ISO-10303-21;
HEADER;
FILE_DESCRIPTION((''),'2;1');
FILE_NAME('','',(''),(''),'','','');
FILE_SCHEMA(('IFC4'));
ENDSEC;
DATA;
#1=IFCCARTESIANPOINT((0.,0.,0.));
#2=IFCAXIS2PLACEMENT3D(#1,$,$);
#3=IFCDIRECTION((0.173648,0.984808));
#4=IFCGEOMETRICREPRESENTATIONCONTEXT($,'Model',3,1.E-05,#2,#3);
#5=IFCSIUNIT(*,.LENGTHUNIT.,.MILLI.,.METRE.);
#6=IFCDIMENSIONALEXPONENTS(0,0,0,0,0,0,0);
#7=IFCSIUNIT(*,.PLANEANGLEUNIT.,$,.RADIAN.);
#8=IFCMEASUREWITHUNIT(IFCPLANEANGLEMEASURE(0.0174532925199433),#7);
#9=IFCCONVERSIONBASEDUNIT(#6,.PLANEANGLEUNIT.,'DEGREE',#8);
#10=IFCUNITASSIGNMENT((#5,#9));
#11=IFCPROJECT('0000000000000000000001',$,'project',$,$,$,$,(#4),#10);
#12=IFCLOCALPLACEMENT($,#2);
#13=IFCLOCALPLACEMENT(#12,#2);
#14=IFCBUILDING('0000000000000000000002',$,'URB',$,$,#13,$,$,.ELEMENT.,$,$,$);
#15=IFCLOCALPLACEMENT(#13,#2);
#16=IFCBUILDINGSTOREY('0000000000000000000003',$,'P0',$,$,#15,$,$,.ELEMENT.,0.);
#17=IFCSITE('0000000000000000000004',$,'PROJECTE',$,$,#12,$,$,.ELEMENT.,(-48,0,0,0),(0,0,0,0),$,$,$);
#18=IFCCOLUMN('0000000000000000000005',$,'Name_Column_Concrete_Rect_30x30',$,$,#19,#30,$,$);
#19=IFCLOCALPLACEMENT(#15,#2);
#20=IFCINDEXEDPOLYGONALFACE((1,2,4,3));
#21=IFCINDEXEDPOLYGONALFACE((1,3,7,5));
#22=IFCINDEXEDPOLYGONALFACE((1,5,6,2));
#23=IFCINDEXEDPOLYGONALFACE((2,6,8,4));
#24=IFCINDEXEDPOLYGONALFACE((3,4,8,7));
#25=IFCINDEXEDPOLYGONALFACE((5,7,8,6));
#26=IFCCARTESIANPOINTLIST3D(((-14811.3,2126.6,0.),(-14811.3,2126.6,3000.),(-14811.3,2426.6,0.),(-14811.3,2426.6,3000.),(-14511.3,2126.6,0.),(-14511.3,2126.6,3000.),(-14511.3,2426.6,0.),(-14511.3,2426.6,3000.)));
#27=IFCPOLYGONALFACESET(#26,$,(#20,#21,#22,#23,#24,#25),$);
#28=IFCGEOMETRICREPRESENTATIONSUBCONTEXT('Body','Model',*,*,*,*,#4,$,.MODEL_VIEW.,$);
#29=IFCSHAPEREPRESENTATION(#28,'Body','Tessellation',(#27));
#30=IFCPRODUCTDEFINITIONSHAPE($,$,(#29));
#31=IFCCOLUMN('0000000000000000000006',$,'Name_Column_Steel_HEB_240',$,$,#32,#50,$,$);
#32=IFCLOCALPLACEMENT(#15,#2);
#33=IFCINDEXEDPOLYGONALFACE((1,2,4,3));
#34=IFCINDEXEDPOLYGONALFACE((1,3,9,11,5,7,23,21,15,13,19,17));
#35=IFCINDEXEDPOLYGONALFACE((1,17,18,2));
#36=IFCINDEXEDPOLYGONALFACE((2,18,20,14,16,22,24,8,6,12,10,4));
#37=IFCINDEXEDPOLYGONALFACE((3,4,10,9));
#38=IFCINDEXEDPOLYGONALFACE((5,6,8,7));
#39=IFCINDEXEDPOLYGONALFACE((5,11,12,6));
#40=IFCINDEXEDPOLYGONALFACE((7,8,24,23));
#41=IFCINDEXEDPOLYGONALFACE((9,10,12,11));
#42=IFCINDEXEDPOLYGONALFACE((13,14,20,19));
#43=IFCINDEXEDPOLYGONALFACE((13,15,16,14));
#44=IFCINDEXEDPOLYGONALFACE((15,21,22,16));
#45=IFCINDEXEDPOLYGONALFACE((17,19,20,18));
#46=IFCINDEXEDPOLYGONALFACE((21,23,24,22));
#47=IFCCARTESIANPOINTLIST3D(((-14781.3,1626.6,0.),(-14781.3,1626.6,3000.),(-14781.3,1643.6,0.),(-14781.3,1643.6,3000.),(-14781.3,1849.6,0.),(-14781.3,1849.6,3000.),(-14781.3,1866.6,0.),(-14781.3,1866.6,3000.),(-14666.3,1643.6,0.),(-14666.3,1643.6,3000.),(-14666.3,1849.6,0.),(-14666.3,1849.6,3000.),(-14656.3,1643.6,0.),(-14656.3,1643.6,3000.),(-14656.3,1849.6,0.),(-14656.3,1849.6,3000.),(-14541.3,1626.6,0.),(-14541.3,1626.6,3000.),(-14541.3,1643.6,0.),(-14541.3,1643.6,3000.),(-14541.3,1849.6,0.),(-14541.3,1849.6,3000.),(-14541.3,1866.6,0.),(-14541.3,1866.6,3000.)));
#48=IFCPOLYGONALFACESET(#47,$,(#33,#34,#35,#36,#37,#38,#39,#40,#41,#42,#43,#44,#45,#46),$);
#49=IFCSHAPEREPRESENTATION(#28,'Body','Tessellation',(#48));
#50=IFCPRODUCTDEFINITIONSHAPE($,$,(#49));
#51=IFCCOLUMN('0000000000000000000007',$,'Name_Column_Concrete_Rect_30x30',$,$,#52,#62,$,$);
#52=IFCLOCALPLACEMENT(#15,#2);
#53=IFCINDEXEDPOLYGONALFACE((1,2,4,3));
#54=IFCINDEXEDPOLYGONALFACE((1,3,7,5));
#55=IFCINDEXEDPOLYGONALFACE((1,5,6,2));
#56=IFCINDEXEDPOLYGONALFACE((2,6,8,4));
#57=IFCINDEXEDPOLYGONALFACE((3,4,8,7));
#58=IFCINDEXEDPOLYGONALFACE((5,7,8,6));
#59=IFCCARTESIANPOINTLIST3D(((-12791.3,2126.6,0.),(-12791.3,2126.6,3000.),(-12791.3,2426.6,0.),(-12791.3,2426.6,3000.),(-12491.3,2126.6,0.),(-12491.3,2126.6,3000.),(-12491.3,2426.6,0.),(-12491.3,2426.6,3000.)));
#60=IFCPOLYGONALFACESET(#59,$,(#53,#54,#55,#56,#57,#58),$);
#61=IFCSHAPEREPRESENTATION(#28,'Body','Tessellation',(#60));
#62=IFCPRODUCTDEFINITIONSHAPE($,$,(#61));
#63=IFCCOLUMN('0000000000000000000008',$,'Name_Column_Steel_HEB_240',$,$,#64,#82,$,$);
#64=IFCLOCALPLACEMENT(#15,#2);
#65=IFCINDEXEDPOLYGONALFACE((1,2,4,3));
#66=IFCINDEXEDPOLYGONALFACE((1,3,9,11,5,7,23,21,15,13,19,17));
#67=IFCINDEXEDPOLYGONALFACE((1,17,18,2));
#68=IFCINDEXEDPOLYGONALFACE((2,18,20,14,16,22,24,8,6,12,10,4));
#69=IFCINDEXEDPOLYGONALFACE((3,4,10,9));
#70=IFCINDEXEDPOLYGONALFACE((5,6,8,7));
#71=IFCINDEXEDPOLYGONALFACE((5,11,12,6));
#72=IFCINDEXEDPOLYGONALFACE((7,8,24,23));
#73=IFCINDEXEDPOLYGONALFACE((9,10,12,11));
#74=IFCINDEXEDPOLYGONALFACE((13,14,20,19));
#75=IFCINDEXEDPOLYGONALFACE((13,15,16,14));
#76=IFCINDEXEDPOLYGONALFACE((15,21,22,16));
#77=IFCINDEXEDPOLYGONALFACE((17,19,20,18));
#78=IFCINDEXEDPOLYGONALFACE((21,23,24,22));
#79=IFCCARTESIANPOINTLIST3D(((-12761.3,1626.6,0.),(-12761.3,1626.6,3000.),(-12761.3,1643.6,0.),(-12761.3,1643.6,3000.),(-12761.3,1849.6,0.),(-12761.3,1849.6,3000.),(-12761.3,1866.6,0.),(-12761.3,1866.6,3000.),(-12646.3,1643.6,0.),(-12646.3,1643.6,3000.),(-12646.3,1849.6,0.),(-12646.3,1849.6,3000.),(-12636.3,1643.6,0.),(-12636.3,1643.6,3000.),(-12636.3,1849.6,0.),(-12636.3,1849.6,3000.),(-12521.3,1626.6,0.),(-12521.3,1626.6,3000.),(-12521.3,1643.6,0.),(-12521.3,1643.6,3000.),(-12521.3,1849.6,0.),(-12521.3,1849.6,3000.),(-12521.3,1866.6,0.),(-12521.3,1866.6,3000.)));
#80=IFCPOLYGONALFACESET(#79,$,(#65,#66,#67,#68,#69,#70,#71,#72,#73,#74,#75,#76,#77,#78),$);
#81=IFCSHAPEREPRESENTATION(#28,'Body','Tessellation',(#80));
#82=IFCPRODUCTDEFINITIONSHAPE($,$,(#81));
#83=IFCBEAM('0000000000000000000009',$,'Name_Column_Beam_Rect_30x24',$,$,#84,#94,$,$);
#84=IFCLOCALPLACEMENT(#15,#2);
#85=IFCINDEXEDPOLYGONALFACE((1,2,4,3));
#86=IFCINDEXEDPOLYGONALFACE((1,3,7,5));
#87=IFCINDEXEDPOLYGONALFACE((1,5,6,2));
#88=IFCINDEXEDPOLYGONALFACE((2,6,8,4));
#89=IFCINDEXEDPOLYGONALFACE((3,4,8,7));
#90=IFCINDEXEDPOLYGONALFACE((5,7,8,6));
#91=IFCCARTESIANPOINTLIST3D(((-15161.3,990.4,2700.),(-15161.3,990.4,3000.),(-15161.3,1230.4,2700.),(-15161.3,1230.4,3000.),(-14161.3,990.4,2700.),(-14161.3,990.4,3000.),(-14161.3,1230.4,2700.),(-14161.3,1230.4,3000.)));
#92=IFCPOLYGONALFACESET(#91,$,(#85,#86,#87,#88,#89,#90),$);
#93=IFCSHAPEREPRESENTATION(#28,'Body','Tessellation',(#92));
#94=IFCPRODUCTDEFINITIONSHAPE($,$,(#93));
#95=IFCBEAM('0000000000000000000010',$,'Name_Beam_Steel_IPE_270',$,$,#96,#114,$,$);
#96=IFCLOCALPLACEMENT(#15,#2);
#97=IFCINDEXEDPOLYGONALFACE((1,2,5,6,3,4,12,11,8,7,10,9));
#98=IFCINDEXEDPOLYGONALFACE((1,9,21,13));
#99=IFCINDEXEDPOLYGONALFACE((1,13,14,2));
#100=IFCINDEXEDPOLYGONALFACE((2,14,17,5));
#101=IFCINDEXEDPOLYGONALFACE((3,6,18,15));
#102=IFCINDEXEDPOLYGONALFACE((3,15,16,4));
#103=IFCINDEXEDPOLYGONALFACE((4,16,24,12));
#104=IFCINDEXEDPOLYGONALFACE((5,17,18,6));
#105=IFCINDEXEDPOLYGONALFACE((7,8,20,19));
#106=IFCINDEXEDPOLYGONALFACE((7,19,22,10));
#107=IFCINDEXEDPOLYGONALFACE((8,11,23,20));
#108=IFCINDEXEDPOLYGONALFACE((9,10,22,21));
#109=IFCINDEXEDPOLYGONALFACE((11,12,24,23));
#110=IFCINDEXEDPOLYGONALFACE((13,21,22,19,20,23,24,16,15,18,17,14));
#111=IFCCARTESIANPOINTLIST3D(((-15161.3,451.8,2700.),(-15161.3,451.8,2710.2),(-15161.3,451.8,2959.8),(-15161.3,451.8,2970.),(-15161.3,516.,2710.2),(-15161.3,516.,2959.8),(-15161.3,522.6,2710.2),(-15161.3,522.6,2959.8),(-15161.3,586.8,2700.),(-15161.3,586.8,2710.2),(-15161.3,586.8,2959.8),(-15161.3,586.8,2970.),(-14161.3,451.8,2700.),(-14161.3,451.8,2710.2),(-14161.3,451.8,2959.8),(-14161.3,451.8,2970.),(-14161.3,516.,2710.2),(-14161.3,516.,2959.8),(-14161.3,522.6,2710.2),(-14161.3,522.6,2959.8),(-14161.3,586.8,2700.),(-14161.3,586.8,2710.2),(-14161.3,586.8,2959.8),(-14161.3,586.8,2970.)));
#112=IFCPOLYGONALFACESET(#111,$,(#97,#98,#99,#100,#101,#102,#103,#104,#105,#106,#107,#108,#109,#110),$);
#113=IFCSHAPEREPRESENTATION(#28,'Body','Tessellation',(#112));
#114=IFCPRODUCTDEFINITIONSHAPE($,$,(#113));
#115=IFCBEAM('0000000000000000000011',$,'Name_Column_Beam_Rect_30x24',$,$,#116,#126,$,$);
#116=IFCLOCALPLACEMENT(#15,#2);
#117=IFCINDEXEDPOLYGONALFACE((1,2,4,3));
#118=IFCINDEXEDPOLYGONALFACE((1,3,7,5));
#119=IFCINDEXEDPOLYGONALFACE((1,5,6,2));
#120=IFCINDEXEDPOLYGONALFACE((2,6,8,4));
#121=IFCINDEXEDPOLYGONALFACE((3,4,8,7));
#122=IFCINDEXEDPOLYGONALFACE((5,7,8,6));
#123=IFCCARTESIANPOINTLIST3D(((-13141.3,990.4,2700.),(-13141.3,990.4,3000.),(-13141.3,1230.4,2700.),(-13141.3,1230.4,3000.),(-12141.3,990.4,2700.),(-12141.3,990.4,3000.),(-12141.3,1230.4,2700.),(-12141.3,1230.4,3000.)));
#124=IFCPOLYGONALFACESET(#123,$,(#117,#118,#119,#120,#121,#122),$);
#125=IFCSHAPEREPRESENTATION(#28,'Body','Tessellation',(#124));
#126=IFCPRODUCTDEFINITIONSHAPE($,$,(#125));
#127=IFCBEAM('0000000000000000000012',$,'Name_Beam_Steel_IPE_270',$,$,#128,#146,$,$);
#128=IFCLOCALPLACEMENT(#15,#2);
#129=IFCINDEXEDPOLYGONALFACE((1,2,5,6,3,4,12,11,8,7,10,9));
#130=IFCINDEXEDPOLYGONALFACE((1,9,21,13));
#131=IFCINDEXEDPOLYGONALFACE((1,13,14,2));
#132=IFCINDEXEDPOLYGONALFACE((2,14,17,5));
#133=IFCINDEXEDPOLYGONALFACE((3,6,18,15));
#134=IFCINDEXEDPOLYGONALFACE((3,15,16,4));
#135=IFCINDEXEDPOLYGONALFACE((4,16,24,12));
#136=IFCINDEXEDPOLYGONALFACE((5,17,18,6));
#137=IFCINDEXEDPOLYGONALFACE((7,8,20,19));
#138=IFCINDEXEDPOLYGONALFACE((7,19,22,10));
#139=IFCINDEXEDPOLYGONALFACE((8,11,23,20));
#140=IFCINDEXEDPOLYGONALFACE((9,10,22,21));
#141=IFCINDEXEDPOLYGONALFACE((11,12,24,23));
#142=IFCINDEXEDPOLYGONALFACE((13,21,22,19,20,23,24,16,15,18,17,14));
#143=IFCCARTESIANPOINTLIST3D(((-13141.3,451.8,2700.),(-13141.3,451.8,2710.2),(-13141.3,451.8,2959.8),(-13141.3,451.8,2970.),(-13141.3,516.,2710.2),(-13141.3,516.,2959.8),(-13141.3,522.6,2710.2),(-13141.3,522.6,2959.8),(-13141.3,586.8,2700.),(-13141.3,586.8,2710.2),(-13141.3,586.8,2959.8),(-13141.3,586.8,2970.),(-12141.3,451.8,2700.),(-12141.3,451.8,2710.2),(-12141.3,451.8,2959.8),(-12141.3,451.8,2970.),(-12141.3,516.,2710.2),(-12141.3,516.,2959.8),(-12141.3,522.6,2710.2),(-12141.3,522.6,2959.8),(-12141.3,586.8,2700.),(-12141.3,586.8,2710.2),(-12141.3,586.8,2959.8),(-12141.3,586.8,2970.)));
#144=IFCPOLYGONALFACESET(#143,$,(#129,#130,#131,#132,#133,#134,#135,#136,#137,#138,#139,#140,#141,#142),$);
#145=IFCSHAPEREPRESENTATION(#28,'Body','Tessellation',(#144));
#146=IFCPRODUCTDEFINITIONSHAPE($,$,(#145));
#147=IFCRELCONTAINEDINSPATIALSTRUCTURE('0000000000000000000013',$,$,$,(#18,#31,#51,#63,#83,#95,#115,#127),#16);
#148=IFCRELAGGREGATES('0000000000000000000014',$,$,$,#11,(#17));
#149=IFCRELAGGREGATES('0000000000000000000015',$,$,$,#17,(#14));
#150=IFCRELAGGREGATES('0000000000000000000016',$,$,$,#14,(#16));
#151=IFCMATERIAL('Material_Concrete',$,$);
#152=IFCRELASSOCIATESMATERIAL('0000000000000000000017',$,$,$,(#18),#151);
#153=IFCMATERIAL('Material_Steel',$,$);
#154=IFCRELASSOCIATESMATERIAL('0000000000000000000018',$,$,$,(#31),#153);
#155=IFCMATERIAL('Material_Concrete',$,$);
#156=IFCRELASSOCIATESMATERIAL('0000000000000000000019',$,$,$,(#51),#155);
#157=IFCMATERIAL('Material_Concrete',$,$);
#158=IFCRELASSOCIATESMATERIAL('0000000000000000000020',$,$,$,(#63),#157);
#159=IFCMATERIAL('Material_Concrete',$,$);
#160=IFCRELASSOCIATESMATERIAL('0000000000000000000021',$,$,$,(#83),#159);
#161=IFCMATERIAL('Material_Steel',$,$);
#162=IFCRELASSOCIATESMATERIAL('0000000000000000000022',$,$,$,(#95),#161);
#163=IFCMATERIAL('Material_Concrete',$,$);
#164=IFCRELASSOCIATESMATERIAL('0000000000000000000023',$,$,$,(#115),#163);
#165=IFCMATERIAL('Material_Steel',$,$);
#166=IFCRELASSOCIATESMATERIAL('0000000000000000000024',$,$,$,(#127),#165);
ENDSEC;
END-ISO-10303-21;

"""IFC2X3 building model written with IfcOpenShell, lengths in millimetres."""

from ifc_helpers import new_model, entity, si_unit, converted_unit, direction, frame, frame_2d, origin, origin_with_axes, place, context, subcontext, project, spatial, polyline, rectangle, outline, extrude, material, element, save


model = new_model("IFC2X3")

# Units and contexts
model_context = context("Model", 3, precision=1e-05, world=origin(), true_north=direction((0.173648, 0.984808)))
body_context = subcontext(model_context, "Body", "Model", "MODEL_VIEW")
ifc_project = project(units=[si_unit("LENGTHUNIT", "METRE", prefix="MILLI"), converted_unit("PLANEANGLEUNIT", "DEGREE", entity("IfcPlaneAngleMeasure", 0.0174532925199433), si_unit("PLANEANGLEUNIT", "RADIAN"), dimensions=[0, 0, 0, 0, 0, 0, 0])], contexts=[model_context])

# Site, building, storey
site_placement = place(None, origin())
site = spatial("IfcSite", under=ifc_project, at=site_placement, Name="PROJECTE", CompositionType="ELEMENT", RefLatitude=(-48, 0, 0, 0), RefLongitude=(0, 0, 0, 0))
building_placement = place(site_placement, origin())
building = spatial("IfcBuilding", under=site, at=building_placement, Name="URB", CompositionType="ELEMENT")
storey_placement = place(building_placement, origin())
storey = spatial("IfcBuildingStorey", under=building, at=storey_placement, Name="P0", CompositionType="ELEMENT", Elevation=0.0)

# Columns
ifc_material_1 = material(Name="Material_Concrete")
column_1_placement = place(storey_placement, frame((-14811.3, 2126.6, 0.0)))
element("IfcColumn", 1, at=column_1_placement, inside=storey, material=ifc_material_1, Name="Name_Column_Concrete_Rect_30x30", context=body_context, shape_type="SweptSolid", body=[
    extrude(rectangle(XDim=300.0, YDim=300.0, at=frame_2d((150.0, 150.0), x_axis=(1.0, 0.0))), origin_with_axes(), (0.0, 0.0, 1.0), 3000.0),
])
ifc_material_2 = material(Name="Material_Steel")
column_2_placement = place(storey_placement, frame((-14781.3, 1626.6, 0.0)))
element("IfcColumn", 2, at=column_2_placement, inside=storey, material=ifc_material_2, Name="Name_Column_Steel_HEB_240", context=body_context, shape_type="SweptSolid", body=[
    extrude(outline(polyline([(0.0, 223.0), (115.0, 223.0), (115.0, 17.0), (0.0, 17.0), (0.0, 0.0), (240.0, 0.0), (240.0, 17.0), (125.0, 17.0), (125.0, 223.0), (240.0, 223.0), (240.0, 240.0), (0.0, 240.0), (0.0, 223.0)])), origin_with_axes(), (0.0, 0.0, 1.0), 3000.0),
])
ifc_material_3 = material(Name="Material_Concrete")
column_3_placement = place(storey_placement, frame((-12791.3, 2126.6, 0.0)))
element("IfcColumn", 3, at=column_3_placement, inside=storey, material=ifc_material_3, Name="Name_Column_Concrete_Rect_30x30", context=body_context, shape_type="SweptSolid", body=[
    extrude(rectangle(XDim=300.0, YDim=300.0, at=frame_2d((150.0, 150.0), x_axis=(1.0, 0.0))), origin_with_axes(), (0.0, 0.0, 1.0), 3000.0),
])
ifc_material_4 = material(Name="Material_Concrete")
column_4_placement = place(storey_placement, frame((-12761.3, 1626.6, 0.0)))
element("IfcColumn", 4, at=column_4_placement, inside=storey, material=ifc_material_4, Name="Name_Column_Steel_HEB_240", context=body_context, shape_type="SweptSolid", body=[
    extrude(outline(polyline([(0.0, 223.0), (115.0, 223.0), (115.0, 17.0), (0.0, 17.0), (0.0, 0.0), (240.0, 0.0), (240.0, 17.0), (125.0, 17.0), (125.0, 223.0), (240.0, 223.0), (240.0, 240.0), (0.0, 240.0), (0.0, 223.0)])), origin_with_axes(), (0.0, 0.0, 1.0), 3000.0),
])

# Beams
ifc_material_5 = material(Name="Material_Concrete")
beam_1_placement = place(storey_placement, frame((-15161.3, 990.4, 2700.0)))
element("IfcBeam", 5, at=beam_1_placement, inside=storey, material=ifc_material_5, Name="Name_Column_Beam_Rect_30x24", context=body_context, shape_type="SweptSolid", body=[
    extrude(rectangle(XDim=240.0, YDim=300.0, at=frame_2d((120.0, 150.0), x_axis=(1.0, 0.0))), frame((0.0, 0.0, 0.0), z_axis=(1.0, 0.0, 0.0), x_axis=(0.0, 1.0, 0.0)), (0.0, 0.0, 1.0), 1000.0),
])
ifc_material_6 = material(Name="Material_Steel")
beam_2_placement = place(storey_placement, frame((-15161.3, 451.8, 2700.0), z_axis=(0.0, 0.0, 1.0), x_axis=(1.0, 0.0, 0.0)))
element("IfcBeam", 6, at=beam_2_placement, inside=storey, material=ifc_material_6, Name="Name_Beam_Steel_IPE_270", context=body_context, shape_type="SweptSolid", body=[
    extrude(outline(polyline([(10.2, 0.0), (10.2, 64.2), (259.8, 64.2), (259.8, 0.0), (270.0, 0.0), (270.0, 135.0), (259.8, 135.0), (259.8, 70.8), (10.2, 70.8), (10.2, 135.0), (0.0, 135.0), (0.0, 0.0), (10.2, 0.0)])), frame((0.0, 135.0, 0.0), z_axis=(1.0, 0.0, 0.0), x_axis=(0.0, 0.0, 1.0)), (0.0, 0.0, 1.0), 1000.0),
])
ifc_material_7 = material(Name="Material_Concrete")
beam_3_placement = place(storey_placement, frame((-13141.3, 990.4, 2700.0)))
element("IfcBeam", 7, at=beam_3_placement, inside=storey, material=ifc_material_7, Name="Name_Column_Beam_Rect_30x24", context=body_context, shape_type="SweptSolid", body=[
    extrude(rectangle(XDim=240.0, YDim=300.0, at=frame_2d((120.0, 150.0), x_axis=(1.0, 0.0))), frame((0.0, 0.0, 0.0), z_axis=(1.0, 0.0, 0.0), x_axis=(0.0, 1.0, 0.0)), (0.0, 0.0, 1.0), 1000.0),
])
ifc_material_8 = material(Name="Material_Steel")
beam_4_placement = place(storey_placement, frame((-13141.3, 451.8, 2700.0), z_axis=(0.0, 0.0, 1.0), x_axis=(1.0, 0.0, 0.0)))
element("IfcBeam", 8, at=beam_4_placement, inside=storey, material=ifc_material_8, Name="Name_Beam_Steel_IPE_270", context=body_context, shape_type="SweptSolid", body=[
    extrude(outline(polyline([(10.2, 0.0), (10.2, 64.2), (259.8, 64.2), (259.8, 0.0), (270.0, 0.0), (270.0, 135.0), (259.8, 135.0), (259.8, 70.8), (10.2, 70.8), (10.2, 135.0), (0.0, 135.0), (0.0, 0.0), (10.2, 0.0)])), frame((0.0, 135.0, 0.0), z_axis=(1.0, 0.0, 0.0), x_axis=(0.0, 0.0, 1.0)), (0.0, 0.0, 1.0), 1000.0),
])

save(model, "model.ifc")
